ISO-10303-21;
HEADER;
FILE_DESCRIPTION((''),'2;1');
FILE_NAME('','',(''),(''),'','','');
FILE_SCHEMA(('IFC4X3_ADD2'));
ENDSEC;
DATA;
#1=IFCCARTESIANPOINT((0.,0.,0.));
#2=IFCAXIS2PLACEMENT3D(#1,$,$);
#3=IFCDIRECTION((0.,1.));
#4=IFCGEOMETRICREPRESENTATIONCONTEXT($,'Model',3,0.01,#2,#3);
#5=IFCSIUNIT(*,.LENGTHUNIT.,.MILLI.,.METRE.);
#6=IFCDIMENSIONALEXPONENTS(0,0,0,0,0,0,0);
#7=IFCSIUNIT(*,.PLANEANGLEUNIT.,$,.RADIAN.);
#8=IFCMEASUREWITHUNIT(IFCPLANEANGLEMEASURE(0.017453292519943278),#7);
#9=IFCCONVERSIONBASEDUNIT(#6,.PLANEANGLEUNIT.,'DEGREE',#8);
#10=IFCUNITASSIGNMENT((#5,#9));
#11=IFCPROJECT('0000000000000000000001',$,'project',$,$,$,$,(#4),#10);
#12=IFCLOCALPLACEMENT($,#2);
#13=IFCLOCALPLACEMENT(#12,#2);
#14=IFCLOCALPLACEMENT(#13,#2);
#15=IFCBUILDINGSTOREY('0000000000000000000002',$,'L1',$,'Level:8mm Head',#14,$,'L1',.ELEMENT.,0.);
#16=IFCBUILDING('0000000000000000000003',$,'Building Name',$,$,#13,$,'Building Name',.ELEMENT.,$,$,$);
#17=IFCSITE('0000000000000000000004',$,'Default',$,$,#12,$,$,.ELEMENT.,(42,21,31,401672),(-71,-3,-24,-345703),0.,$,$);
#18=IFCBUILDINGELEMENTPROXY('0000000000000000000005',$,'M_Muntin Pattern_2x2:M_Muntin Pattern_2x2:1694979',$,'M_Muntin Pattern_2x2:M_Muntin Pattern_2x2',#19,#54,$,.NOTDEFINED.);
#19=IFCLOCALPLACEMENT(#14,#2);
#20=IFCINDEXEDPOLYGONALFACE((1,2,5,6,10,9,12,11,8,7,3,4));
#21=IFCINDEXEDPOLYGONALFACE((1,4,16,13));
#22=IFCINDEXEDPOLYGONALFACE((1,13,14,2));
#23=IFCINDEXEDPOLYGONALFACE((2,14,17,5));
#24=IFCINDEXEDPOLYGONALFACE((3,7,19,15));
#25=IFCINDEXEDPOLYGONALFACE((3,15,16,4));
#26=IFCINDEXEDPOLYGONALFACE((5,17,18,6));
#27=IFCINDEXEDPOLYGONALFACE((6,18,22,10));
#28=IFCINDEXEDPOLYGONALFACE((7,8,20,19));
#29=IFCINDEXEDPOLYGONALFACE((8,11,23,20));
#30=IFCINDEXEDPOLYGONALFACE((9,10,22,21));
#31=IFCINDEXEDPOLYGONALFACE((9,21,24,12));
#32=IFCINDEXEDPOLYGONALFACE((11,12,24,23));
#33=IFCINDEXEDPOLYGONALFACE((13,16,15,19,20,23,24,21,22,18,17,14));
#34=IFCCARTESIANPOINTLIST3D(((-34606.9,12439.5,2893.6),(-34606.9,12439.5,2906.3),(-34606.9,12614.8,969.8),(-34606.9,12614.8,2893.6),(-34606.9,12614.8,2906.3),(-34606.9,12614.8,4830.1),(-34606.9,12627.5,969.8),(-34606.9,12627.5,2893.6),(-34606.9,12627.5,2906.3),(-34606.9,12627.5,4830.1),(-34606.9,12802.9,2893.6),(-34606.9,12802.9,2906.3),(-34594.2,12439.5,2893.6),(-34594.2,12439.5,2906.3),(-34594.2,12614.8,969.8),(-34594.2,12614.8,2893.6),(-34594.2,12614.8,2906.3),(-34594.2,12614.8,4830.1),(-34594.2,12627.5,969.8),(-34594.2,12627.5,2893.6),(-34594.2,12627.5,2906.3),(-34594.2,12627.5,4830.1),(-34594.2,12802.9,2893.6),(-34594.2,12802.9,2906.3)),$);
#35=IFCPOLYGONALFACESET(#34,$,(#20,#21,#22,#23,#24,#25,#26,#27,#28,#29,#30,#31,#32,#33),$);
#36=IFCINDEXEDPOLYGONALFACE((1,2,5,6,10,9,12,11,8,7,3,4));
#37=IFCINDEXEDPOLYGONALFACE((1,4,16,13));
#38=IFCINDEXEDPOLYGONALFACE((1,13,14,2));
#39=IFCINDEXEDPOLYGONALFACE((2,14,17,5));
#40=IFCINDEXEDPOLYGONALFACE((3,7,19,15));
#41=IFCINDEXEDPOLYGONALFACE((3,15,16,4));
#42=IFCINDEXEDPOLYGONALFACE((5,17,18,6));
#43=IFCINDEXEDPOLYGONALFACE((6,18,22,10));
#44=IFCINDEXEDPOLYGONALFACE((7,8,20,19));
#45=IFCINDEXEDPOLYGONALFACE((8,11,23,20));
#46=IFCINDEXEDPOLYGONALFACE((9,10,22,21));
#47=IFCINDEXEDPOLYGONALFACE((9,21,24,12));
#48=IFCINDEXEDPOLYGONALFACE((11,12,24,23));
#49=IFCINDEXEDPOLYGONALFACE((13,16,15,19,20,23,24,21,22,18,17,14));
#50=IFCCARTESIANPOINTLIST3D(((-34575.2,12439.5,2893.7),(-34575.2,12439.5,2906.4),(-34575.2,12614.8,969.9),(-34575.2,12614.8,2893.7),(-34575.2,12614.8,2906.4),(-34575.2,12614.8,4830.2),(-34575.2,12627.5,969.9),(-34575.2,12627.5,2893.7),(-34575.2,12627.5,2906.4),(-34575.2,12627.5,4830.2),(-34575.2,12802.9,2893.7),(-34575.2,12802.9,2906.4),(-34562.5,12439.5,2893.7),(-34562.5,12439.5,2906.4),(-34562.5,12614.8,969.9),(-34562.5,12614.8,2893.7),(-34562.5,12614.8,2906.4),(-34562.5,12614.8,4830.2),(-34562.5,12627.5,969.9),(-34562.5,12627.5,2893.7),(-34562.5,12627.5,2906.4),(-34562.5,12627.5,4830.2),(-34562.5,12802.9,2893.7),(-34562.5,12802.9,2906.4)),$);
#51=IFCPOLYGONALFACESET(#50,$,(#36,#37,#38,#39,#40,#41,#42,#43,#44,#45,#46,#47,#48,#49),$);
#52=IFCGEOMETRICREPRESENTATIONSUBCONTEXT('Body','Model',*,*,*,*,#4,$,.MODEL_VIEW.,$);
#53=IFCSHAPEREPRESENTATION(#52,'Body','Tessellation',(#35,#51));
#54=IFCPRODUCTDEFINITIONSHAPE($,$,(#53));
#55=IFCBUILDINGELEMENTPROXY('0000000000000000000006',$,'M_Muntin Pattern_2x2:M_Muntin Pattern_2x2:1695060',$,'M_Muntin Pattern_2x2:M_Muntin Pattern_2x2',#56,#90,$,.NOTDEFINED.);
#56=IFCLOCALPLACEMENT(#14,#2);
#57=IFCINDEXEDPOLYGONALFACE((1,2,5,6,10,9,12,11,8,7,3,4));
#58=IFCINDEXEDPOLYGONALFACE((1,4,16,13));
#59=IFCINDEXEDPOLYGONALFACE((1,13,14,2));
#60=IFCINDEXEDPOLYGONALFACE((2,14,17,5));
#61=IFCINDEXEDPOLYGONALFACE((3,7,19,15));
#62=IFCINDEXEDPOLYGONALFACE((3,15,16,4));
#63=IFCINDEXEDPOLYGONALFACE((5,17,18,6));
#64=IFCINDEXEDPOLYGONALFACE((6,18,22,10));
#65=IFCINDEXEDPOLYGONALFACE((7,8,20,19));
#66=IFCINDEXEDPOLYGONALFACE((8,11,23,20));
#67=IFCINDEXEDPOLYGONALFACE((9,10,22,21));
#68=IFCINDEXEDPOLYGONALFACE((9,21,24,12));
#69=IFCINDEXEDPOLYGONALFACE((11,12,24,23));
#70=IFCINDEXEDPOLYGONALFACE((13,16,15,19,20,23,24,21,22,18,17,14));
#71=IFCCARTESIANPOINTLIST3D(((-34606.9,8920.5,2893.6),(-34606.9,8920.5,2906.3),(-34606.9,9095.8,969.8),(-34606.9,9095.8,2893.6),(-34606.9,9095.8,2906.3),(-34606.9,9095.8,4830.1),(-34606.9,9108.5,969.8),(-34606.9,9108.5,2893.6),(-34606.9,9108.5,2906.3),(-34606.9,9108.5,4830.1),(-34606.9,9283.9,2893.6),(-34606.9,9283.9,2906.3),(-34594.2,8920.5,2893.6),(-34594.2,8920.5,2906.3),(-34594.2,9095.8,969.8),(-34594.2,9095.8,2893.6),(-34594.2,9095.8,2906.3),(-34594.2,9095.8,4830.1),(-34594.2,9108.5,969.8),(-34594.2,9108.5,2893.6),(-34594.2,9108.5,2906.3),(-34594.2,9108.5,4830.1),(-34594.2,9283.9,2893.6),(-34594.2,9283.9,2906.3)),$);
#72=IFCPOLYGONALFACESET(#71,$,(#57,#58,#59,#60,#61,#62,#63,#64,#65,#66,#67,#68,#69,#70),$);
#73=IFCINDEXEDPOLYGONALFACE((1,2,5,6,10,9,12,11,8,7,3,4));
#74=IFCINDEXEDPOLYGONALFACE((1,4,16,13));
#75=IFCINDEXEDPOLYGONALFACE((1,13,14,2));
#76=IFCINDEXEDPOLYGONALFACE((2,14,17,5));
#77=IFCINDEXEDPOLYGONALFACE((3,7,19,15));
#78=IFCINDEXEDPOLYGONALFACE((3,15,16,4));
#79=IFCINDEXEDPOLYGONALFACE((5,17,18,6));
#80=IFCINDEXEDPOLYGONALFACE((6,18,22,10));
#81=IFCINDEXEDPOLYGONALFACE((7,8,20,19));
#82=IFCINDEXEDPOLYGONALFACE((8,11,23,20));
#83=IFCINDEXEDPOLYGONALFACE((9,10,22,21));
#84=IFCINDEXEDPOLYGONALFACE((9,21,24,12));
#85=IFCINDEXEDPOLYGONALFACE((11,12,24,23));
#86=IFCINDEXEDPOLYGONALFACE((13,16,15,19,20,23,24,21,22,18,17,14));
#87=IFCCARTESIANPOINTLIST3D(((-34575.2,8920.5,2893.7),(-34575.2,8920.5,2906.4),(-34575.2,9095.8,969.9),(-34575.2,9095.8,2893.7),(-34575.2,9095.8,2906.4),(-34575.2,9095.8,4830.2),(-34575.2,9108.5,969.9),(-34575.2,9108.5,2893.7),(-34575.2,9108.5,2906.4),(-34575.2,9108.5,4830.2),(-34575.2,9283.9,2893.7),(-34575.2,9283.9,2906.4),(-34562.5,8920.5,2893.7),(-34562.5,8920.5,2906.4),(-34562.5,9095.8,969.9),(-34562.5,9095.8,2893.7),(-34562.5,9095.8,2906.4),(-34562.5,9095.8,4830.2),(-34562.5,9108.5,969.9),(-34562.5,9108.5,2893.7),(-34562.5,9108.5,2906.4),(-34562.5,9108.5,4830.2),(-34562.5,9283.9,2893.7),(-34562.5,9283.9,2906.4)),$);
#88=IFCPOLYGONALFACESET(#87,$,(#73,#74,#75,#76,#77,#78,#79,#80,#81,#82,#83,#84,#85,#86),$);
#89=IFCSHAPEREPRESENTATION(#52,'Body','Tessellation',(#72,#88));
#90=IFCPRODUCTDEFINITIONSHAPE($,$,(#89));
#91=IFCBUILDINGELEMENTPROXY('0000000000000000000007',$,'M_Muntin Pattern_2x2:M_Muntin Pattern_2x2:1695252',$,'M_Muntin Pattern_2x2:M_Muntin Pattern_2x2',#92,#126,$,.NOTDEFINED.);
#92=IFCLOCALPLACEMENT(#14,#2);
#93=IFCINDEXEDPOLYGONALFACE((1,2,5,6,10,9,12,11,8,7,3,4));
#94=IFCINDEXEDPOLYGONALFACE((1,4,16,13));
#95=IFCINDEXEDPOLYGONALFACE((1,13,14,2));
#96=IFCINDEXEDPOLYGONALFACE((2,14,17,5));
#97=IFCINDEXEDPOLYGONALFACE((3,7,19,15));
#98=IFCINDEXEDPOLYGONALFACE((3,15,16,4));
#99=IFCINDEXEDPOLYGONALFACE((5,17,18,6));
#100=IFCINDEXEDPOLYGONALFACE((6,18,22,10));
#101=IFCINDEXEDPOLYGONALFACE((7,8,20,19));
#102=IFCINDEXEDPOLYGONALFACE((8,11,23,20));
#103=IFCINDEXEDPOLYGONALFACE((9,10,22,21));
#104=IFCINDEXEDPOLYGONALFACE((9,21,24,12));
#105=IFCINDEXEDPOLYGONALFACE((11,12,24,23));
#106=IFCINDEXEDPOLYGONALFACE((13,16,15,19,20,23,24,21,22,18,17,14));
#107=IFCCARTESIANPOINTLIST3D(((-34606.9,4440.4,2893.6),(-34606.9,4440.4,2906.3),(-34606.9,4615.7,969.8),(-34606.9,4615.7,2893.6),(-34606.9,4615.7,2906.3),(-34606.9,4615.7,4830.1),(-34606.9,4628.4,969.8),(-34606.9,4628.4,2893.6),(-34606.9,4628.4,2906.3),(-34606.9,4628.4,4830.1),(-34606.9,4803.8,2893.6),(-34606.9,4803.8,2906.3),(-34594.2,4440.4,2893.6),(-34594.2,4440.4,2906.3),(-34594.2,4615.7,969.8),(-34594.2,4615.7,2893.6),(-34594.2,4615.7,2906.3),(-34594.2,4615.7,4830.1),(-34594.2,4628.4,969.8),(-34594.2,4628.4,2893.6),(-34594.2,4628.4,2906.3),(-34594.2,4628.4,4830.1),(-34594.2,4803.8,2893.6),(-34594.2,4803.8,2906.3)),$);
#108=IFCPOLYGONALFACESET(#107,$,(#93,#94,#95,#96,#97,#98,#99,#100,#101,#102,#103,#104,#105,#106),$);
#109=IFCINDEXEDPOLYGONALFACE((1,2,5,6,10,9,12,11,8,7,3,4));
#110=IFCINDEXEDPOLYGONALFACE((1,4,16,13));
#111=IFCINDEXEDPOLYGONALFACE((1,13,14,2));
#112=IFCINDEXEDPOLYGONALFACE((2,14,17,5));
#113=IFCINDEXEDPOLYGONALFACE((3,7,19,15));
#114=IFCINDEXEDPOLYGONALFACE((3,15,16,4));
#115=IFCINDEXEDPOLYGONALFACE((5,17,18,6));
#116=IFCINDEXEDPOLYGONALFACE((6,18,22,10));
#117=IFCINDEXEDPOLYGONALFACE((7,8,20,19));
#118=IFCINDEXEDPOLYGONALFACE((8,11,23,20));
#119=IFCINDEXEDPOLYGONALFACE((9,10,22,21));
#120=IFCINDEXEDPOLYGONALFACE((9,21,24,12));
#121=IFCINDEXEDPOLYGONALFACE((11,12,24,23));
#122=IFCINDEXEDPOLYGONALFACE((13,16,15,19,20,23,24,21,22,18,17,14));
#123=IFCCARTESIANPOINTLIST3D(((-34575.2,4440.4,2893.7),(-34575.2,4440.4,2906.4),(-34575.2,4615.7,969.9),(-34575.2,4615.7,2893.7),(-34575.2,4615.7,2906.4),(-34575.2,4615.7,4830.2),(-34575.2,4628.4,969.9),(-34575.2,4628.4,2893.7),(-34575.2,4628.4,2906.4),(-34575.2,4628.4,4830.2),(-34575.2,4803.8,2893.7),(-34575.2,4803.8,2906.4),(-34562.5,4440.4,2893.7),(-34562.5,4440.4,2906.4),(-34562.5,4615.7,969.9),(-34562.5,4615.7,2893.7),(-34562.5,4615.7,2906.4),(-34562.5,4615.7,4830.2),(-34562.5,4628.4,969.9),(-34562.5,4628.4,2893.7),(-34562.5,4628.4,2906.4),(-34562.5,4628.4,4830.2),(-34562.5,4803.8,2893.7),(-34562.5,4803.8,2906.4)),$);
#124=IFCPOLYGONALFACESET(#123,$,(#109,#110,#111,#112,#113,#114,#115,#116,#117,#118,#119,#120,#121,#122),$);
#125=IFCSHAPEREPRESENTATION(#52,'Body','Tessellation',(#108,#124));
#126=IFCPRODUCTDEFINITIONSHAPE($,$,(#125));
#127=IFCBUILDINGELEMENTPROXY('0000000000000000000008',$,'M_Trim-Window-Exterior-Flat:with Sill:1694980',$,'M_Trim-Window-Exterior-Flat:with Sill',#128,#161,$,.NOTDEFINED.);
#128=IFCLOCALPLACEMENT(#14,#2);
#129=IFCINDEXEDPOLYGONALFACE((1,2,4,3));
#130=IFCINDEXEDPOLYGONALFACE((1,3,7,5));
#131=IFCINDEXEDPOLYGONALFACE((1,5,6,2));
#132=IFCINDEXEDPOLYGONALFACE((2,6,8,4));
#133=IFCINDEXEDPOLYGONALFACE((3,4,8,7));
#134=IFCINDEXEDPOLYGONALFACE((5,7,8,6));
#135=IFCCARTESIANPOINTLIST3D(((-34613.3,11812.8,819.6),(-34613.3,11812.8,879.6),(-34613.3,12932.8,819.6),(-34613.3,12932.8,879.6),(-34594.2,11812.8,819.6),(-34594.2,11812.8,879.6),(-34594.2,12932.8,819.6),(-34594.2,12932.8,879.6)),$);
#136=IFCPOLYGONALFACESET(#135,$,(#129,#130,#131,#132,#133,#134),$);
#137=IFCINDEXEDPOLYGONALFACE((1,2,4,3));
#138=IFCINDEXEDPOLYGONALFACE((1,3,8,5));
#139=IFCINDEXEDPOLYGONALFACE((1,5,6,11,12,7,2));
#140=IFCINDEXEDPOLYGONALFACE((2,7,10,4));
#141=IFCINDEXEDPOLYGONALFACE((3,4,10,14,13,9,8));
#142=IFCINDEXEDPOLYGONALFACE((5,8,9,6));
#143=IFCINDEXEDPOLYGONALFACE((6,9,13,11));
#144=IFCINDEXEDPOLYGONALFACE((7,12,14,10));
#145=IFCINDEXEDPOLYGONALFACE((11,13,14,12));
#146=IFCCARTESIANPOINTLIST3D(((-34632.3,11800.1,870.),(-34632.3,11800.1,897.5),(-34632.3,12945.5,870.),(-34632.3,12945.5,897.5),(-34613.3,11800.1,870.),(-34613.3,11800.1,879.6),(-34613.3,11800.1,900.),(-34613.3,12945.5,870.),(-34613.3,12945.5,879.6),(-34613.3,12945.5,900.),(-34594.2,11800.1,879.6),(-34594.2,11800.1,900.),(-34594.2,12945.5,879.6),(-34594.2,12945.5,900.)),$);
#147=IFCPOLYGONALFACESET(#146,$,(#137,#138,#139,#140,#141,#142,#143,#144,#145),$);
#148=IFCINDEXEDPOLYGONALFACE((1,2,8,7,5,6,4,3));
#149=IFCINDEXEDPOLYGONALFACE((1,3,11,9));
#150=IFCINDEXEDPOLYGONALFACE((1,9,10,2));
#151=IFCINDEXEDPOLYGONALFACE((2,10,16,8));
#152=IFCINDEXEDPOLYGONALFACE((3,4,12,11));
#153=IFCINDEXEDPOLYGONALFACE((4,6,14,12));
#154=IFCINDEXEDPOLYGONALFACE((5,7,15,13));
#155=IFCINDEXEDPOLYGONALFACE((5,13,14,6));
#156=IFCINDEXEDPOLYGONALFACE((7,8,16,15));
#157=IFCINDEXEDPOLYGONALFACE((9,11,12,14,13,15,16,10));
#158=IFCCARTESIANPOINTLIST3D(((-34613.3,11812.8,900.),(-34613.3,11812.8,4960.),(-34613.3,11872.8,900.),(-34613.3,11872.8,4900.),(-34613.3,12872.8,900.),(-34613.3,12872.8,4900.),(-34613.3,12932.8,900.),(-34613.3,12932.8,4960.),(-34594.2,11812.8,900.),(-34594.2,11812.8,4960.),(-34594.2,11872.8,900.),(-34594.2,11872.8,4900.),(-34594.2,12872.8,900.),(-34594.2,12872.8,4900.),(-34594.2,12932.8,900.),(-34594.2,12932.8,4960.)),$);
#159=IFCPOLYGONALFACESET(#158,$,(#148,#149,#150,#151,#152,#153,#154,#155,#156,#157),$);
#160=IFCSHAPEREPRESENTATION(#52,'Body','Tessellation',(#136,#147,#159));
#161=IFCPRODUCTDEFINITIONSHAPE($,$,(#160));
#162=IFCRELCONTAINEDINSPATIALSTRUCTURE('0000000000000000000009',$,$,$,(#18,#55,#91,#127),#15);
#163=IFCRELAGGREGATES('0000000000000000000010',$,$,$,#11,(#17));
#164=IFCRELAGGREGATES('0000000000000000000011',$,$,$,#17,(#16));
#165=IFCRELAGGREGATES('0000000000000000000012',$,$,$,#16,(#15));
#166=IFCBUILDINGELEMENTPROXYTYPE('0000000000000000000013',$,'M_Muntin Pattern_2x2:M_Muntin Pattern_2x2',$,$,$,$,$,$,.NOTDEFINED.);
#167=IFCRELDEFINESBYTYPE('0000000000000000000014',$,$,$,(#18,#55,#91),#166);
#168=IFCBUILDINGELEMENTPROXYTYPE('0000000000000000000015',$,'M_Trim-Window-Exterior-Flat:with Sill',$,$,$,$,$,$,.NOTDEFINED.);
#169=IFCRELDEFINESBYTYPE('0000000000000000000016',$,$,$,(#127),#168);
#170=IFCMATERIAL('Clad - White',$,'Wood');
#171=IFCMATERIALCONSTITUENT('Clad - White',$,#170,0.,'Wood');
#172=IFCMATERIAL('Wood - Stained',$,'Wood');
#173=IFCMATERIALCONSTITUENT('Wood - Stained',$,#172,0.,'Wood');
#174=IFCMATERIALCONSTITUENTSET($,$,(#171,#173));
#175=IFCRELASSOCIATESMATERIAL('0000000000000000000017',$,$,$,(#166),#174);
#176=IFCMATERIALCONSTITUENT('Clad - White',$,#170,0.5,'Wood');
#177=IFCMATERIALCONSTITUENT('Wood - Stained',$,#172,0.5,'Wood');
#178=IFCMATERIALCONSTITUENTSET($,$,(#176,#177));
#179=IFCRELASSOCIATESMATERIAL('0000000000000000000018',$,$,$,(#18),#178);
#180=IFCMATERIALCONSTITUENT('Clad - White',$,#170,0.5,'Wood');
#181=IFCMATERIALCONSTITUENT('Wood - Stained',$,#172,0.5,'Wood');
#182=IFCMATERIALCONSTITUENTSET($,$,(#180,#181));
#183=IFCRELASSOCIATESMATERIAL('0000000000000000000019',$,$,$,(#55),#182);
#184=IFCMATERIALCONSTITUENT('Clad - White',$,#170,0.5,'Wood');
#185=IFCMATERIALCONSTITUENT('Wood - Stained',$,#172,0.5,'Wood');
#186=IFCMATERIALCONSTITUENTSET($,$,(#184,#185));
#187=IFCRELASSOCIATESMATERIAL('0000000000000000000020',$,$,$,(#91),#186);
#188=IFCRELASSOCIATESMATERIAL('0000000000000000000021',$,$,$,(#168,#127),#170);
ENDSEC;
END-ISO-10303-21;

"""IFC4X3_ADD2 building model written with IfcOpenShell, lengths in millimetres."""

from ifc_helpers import new_model, entity, si_unit, converted_unit, direction, frame, frame_2d, origin, place, context, subcontext, project, spatial, polyline, rectangle, outline, extrude, source, transform, mapped, material, constituent, constituent_set, type_object, type_shapes, element, save


model = new_model("IFC4X3_ADD2")

# Units and contexts
model_context = context("Model", 3, precision=0.01, world=origin(), true_north=direction((0.0, 1.0)))
body_context = subcontext(model_context, "Body", "Model", "MODEL_VIEW")
ifc_project = project(units=[si_unit("LENGTHUNIT", "METRE", prefix="MILLI"), converted_unit("PLANEANGLEUNIT", "DEGREE", entity("IfcPlaneAngleMeasure", 0.017453292519943278), si_unit("PLANEANGLEUNIT", "RADIAN"), dimensions=[0, 0, 0, 0, 0, 0, 0])], contexts=[model_context])

# Site, building, storey
site_placement = place(None, origin())
site = spatial("IfcSite", under=ifc_project, at=site_placement, Name="Default", CompositionType="ELEMENT", RefLatitude=(42, 21, 31, 401672), RefLongitude=(-71, -3, -24, -345703), RefElevation=0.0)
building_placement = place(site_placement, origin())
building = spatial("IfcBuilding", under=site, at=building_placement, Name="Building Name", LongName="Building Name", CompositionType="ELEMENT")
storey_placement = place(building_placement, origin())
storey = spatial("IfcBuildingStorey", under=building, at=storey_placement, Name="L1", ObjectType="Level:8mm Head", LongName="L1", CompositionType="ELEMENT", Elevation=0.0)

# Building element proxies
ifc_material_1 = material(Name="Clad - White", Category="Wood")
ifc_material_2 = material(Name="Wood - Stained", Category="Wood")
ifc_constituent_1 = constituent(ifc_material_1, Name="Clad - White", Category="Wood", fraction=0.5)
ifc_constituent_2 = constituent(ifc_material_2, Name="Wood - Stained", Category="Wood", fraction=0.5)
ifc_constituent_set_1 = constituent_set(constituents=[ifc_constituent_1, ifc_constituent_2])
ifc_constituent_3 = constituent(ifc_material_1, Name="Clad - White", Category="Wood", fraction=0.0)
ifc_constituent_4 = constituent(ifc_material_2, Name="Wood - Stained", Category="Wood", fraction=0.0)
ifc_constituent_set_2 = constituent_set(constituents=[ifc_constituent_3, ifc_constituent_4])
building_element_proxy_type_1 = type_object("IfcBuildingElementProxyType", Name="M_Muntin Pattern_2x2:M_Muntin Pattern_2x2", PredefinedType="NOTDEFINED", material=ifc_constituent_set_2)
shared_shape_1 = source(origin(), body_context, "Body", "SweptSolid", [
    extrude(outline(polyline([(6.4, -6.4), (1930.1, -6.4), (1930.1, 6.3), (6.4, 6.3), (6.4, 181.7), (-6.3, 181.7), (-6.3, 6.3), (-1930.2, 6.3), (-1930.2, -6.4), (-6.3, -6.4), (-6.3, -181.7), (6.4, -181.7), (6.4, -6.4)])), frame((0.0, -22.2, 1930.1), z_axis=(0.0, 1.0, 0.0), x_axis=(0.0, 0.0, 1.0)), (0.0, 0.0, 1.0), 12.7),
    extrude(outline(polyline([(6.4, -6.4), (1930.2, -6.4), (1930.2, 6.3), (6.4, 6.3), (6.4, 181.7), (-6.3, 181.7), (-6.3, 6.3), (-1930.2, 6.3), (-1930.2, -6.4), (-6.3, -6.4), (-6.3, -181.7), (6.4, -181.7), (6.4, -6.4)])), frame((0.0, 9.5, 1930.2), z_axis=(0.0, 1.0, 0.0), x_axis=(0.0, 0.0, 1.0)), (0.0, 0.0, 1.0), 12.7),
])
type_shapes(building_element_proxy_type_1, [shared_shape_1])
proxy_1_placement = place(storey_placement, frame((-34584.7, 12621.2, 969.9), z_axis=(0.0, 0.0, 1.0), x_axis=(0.0, -1.0, 0.0)))
element("IfcBuildingElementProxy", 1, at=proxy_1_placement, inside=storey, type_object=building_element_proxy_type_1, material=ifc_constituent_set_1, Name="M_Muntin Pattern_2x2:M_Muntin Pattern_2x2:1694979", ObjectType="M_Muntin Pattern_2x2:M_Muntin Pattern_2x2", PredefinedType="NOTDEFINED", context=body_context, shape_type="MappedRepresentation", body=[
    mapped(shared_shape_1, transform((0.0, 0.0, 0.0), scale=1.0)),
])
ifc_constituent_5 = constituent(ifc_material_1, Name="Clad - White", Category="Wood", fraction=0.5)
ifc_constituent_6 = constituent(ifc_material_2, Name="Wood - Stained", Category="Wood", fraction=0.5)
ifc_constituent_set_3 = constituent_set(constituents=[ifc_constituent_5, ifc_constituent_6])
proxy_2_placement = place(storey_placement, frame((-34584.7, 9102.2, 969.9), z_axis=(0.0, 0.0, 1.0), x_axis=(0.0, -1.0, 0.0)))
element("IfcBuildingElementProxy", 2, at=proxy_2_placement, inside=storey, type_object=building_element_proxy_type_1, material=ifc_constituent_set_3, Name="M_Muntin Pattern_2x2:M_Muntin Pattern_2x2:1695060", ObjectType="M_Muntin Pattern_2x2:M_Muntin Pattern_2x2", PredefinedType="NOTDEFINED", context=body_context, shape_type="MappedRepresentation", body=[
    mapped(shared_shape_1, transform((0.0, 0.0, 0.0), scale=1.0)),
])
ifc_constituent_7 = constituent(ifc_material_1, Name="Clad - White", Category="Wood", fraction=0.5)
ifc_constituent_8 = constituent(ifc_material_2, Name="Wood - Stained", Category="Wood", fraction=0.5)
ifc_constituent_set_4 = constituent_set(constituents=[ifc_constituent_7, ifc_constituent_8])
proxy_3_placement = place(storey_placement, frame((-34584.7, 4622.1, 969.9), z_axis=(0.0, 0.0, 1.0), x_axis=(0.0, -1.0, 0.0)))
element("IfcBuildingElementProxy", 3, at=proxy_3_placement, inside=storey, type_object=building_element_proxy_type_1, material=ifc_constituent_set_4, Name="M_Muntin Pattern_2x2:M_Muntin Pattern_2x2:1695252", ObjectType="M_Muntin Pattern_2x2:M_Muntin Pattern_2x2", PredefinedType="NOTDEFINED", context=body_context, shape_type="MappedRepresentation", body=[
    mapped(shared_shape_1, transform((0.0, 0.0, 0.0), scale=1.0)),
])
building_element_proxy_type_2 = type_object("IfcBuildingElementProxyType", Name="M_Trim-Window-Exterior-Flat:with Sill", PredefinedType="NOTDEFINED", material=ifc_material_1)
shared_shape_2 = source(origin(), body_context, "Body", "SweptSolid", [
    extrude(rectangle(XDim=1120.0, YDim=60.0, at=frame_2d((0.0, 0.0), x_axis=(1.0, 0.0))), frame((0.0, -4050.4, 0.0), z_axis=(0.0, 0.0, 1.0), x_axis=(-1.0, 0.0, 0.0)), (0.0, 0.0, 1.0), 19.0),
    extrude(outline(polyline([(-19.0, -15.2), (0.0, -15.2), (0.0, -5.7), (19.0, -5.7), (19.0, 14.8), (0.0, 14.8), (-19.0, 12.3), (-19.0, -15.2)])), frame((-572.7, -4014.8, 19.0), z_axis=(1.0, 0.0, 0.0), x_axis=(0.0, 0.0, -1.0)), (0.0, 0.0, 1.0), 1145.4),
    extrude(outline(polyline([(-2045.0, -560.0), (2015.0, -560.0), (2015.0, -500.0), (-1985.0, -500.0), (-1985.0, 500.0), (2015.0, 500.0), (2015.0, 560.0), (-2045.0, 560.0), (-2045.0, -560.0)])), frame((0.0, -1985.0, 0.0), z_axis=(0.0, 0.0, 1.0), x_axis=(0.0, -1.0, 0.0)), (0.0, 0.0, 1.0), 19.0),
])
type_shapes(building_element_proxy_type_2, [shared_shape_2])
for number, where, z_axis, x_axis, name in (
    (4, (-34594.2, 12372.8, 4900.0), (-1.0, 0.0, 0.0), (0.0, -1.0, 0.0), "M_Trim-Window-Exterior-Flat:with Sill:1694980"),
):
    element("IfcBuildingElementProxy", number, at=place(storey_placement, frame(where, z_axis=z_axis, x_axis=x_axis)), inside=storey, type_object=building_element_proxy_type_2, material=ifc_material_1, Name=name, ObjectType="M_Trim-Window-Exterior-Flat:with Sill", PredefinedType="NOTDEFINED", context=body_context, shape_type="MappedRepresentation", body=[
        mapped(shared_shape_2, transform((0.0, 0.0, 0.0), scale=1.0)),
    ])

save(model, "model.ifc")
